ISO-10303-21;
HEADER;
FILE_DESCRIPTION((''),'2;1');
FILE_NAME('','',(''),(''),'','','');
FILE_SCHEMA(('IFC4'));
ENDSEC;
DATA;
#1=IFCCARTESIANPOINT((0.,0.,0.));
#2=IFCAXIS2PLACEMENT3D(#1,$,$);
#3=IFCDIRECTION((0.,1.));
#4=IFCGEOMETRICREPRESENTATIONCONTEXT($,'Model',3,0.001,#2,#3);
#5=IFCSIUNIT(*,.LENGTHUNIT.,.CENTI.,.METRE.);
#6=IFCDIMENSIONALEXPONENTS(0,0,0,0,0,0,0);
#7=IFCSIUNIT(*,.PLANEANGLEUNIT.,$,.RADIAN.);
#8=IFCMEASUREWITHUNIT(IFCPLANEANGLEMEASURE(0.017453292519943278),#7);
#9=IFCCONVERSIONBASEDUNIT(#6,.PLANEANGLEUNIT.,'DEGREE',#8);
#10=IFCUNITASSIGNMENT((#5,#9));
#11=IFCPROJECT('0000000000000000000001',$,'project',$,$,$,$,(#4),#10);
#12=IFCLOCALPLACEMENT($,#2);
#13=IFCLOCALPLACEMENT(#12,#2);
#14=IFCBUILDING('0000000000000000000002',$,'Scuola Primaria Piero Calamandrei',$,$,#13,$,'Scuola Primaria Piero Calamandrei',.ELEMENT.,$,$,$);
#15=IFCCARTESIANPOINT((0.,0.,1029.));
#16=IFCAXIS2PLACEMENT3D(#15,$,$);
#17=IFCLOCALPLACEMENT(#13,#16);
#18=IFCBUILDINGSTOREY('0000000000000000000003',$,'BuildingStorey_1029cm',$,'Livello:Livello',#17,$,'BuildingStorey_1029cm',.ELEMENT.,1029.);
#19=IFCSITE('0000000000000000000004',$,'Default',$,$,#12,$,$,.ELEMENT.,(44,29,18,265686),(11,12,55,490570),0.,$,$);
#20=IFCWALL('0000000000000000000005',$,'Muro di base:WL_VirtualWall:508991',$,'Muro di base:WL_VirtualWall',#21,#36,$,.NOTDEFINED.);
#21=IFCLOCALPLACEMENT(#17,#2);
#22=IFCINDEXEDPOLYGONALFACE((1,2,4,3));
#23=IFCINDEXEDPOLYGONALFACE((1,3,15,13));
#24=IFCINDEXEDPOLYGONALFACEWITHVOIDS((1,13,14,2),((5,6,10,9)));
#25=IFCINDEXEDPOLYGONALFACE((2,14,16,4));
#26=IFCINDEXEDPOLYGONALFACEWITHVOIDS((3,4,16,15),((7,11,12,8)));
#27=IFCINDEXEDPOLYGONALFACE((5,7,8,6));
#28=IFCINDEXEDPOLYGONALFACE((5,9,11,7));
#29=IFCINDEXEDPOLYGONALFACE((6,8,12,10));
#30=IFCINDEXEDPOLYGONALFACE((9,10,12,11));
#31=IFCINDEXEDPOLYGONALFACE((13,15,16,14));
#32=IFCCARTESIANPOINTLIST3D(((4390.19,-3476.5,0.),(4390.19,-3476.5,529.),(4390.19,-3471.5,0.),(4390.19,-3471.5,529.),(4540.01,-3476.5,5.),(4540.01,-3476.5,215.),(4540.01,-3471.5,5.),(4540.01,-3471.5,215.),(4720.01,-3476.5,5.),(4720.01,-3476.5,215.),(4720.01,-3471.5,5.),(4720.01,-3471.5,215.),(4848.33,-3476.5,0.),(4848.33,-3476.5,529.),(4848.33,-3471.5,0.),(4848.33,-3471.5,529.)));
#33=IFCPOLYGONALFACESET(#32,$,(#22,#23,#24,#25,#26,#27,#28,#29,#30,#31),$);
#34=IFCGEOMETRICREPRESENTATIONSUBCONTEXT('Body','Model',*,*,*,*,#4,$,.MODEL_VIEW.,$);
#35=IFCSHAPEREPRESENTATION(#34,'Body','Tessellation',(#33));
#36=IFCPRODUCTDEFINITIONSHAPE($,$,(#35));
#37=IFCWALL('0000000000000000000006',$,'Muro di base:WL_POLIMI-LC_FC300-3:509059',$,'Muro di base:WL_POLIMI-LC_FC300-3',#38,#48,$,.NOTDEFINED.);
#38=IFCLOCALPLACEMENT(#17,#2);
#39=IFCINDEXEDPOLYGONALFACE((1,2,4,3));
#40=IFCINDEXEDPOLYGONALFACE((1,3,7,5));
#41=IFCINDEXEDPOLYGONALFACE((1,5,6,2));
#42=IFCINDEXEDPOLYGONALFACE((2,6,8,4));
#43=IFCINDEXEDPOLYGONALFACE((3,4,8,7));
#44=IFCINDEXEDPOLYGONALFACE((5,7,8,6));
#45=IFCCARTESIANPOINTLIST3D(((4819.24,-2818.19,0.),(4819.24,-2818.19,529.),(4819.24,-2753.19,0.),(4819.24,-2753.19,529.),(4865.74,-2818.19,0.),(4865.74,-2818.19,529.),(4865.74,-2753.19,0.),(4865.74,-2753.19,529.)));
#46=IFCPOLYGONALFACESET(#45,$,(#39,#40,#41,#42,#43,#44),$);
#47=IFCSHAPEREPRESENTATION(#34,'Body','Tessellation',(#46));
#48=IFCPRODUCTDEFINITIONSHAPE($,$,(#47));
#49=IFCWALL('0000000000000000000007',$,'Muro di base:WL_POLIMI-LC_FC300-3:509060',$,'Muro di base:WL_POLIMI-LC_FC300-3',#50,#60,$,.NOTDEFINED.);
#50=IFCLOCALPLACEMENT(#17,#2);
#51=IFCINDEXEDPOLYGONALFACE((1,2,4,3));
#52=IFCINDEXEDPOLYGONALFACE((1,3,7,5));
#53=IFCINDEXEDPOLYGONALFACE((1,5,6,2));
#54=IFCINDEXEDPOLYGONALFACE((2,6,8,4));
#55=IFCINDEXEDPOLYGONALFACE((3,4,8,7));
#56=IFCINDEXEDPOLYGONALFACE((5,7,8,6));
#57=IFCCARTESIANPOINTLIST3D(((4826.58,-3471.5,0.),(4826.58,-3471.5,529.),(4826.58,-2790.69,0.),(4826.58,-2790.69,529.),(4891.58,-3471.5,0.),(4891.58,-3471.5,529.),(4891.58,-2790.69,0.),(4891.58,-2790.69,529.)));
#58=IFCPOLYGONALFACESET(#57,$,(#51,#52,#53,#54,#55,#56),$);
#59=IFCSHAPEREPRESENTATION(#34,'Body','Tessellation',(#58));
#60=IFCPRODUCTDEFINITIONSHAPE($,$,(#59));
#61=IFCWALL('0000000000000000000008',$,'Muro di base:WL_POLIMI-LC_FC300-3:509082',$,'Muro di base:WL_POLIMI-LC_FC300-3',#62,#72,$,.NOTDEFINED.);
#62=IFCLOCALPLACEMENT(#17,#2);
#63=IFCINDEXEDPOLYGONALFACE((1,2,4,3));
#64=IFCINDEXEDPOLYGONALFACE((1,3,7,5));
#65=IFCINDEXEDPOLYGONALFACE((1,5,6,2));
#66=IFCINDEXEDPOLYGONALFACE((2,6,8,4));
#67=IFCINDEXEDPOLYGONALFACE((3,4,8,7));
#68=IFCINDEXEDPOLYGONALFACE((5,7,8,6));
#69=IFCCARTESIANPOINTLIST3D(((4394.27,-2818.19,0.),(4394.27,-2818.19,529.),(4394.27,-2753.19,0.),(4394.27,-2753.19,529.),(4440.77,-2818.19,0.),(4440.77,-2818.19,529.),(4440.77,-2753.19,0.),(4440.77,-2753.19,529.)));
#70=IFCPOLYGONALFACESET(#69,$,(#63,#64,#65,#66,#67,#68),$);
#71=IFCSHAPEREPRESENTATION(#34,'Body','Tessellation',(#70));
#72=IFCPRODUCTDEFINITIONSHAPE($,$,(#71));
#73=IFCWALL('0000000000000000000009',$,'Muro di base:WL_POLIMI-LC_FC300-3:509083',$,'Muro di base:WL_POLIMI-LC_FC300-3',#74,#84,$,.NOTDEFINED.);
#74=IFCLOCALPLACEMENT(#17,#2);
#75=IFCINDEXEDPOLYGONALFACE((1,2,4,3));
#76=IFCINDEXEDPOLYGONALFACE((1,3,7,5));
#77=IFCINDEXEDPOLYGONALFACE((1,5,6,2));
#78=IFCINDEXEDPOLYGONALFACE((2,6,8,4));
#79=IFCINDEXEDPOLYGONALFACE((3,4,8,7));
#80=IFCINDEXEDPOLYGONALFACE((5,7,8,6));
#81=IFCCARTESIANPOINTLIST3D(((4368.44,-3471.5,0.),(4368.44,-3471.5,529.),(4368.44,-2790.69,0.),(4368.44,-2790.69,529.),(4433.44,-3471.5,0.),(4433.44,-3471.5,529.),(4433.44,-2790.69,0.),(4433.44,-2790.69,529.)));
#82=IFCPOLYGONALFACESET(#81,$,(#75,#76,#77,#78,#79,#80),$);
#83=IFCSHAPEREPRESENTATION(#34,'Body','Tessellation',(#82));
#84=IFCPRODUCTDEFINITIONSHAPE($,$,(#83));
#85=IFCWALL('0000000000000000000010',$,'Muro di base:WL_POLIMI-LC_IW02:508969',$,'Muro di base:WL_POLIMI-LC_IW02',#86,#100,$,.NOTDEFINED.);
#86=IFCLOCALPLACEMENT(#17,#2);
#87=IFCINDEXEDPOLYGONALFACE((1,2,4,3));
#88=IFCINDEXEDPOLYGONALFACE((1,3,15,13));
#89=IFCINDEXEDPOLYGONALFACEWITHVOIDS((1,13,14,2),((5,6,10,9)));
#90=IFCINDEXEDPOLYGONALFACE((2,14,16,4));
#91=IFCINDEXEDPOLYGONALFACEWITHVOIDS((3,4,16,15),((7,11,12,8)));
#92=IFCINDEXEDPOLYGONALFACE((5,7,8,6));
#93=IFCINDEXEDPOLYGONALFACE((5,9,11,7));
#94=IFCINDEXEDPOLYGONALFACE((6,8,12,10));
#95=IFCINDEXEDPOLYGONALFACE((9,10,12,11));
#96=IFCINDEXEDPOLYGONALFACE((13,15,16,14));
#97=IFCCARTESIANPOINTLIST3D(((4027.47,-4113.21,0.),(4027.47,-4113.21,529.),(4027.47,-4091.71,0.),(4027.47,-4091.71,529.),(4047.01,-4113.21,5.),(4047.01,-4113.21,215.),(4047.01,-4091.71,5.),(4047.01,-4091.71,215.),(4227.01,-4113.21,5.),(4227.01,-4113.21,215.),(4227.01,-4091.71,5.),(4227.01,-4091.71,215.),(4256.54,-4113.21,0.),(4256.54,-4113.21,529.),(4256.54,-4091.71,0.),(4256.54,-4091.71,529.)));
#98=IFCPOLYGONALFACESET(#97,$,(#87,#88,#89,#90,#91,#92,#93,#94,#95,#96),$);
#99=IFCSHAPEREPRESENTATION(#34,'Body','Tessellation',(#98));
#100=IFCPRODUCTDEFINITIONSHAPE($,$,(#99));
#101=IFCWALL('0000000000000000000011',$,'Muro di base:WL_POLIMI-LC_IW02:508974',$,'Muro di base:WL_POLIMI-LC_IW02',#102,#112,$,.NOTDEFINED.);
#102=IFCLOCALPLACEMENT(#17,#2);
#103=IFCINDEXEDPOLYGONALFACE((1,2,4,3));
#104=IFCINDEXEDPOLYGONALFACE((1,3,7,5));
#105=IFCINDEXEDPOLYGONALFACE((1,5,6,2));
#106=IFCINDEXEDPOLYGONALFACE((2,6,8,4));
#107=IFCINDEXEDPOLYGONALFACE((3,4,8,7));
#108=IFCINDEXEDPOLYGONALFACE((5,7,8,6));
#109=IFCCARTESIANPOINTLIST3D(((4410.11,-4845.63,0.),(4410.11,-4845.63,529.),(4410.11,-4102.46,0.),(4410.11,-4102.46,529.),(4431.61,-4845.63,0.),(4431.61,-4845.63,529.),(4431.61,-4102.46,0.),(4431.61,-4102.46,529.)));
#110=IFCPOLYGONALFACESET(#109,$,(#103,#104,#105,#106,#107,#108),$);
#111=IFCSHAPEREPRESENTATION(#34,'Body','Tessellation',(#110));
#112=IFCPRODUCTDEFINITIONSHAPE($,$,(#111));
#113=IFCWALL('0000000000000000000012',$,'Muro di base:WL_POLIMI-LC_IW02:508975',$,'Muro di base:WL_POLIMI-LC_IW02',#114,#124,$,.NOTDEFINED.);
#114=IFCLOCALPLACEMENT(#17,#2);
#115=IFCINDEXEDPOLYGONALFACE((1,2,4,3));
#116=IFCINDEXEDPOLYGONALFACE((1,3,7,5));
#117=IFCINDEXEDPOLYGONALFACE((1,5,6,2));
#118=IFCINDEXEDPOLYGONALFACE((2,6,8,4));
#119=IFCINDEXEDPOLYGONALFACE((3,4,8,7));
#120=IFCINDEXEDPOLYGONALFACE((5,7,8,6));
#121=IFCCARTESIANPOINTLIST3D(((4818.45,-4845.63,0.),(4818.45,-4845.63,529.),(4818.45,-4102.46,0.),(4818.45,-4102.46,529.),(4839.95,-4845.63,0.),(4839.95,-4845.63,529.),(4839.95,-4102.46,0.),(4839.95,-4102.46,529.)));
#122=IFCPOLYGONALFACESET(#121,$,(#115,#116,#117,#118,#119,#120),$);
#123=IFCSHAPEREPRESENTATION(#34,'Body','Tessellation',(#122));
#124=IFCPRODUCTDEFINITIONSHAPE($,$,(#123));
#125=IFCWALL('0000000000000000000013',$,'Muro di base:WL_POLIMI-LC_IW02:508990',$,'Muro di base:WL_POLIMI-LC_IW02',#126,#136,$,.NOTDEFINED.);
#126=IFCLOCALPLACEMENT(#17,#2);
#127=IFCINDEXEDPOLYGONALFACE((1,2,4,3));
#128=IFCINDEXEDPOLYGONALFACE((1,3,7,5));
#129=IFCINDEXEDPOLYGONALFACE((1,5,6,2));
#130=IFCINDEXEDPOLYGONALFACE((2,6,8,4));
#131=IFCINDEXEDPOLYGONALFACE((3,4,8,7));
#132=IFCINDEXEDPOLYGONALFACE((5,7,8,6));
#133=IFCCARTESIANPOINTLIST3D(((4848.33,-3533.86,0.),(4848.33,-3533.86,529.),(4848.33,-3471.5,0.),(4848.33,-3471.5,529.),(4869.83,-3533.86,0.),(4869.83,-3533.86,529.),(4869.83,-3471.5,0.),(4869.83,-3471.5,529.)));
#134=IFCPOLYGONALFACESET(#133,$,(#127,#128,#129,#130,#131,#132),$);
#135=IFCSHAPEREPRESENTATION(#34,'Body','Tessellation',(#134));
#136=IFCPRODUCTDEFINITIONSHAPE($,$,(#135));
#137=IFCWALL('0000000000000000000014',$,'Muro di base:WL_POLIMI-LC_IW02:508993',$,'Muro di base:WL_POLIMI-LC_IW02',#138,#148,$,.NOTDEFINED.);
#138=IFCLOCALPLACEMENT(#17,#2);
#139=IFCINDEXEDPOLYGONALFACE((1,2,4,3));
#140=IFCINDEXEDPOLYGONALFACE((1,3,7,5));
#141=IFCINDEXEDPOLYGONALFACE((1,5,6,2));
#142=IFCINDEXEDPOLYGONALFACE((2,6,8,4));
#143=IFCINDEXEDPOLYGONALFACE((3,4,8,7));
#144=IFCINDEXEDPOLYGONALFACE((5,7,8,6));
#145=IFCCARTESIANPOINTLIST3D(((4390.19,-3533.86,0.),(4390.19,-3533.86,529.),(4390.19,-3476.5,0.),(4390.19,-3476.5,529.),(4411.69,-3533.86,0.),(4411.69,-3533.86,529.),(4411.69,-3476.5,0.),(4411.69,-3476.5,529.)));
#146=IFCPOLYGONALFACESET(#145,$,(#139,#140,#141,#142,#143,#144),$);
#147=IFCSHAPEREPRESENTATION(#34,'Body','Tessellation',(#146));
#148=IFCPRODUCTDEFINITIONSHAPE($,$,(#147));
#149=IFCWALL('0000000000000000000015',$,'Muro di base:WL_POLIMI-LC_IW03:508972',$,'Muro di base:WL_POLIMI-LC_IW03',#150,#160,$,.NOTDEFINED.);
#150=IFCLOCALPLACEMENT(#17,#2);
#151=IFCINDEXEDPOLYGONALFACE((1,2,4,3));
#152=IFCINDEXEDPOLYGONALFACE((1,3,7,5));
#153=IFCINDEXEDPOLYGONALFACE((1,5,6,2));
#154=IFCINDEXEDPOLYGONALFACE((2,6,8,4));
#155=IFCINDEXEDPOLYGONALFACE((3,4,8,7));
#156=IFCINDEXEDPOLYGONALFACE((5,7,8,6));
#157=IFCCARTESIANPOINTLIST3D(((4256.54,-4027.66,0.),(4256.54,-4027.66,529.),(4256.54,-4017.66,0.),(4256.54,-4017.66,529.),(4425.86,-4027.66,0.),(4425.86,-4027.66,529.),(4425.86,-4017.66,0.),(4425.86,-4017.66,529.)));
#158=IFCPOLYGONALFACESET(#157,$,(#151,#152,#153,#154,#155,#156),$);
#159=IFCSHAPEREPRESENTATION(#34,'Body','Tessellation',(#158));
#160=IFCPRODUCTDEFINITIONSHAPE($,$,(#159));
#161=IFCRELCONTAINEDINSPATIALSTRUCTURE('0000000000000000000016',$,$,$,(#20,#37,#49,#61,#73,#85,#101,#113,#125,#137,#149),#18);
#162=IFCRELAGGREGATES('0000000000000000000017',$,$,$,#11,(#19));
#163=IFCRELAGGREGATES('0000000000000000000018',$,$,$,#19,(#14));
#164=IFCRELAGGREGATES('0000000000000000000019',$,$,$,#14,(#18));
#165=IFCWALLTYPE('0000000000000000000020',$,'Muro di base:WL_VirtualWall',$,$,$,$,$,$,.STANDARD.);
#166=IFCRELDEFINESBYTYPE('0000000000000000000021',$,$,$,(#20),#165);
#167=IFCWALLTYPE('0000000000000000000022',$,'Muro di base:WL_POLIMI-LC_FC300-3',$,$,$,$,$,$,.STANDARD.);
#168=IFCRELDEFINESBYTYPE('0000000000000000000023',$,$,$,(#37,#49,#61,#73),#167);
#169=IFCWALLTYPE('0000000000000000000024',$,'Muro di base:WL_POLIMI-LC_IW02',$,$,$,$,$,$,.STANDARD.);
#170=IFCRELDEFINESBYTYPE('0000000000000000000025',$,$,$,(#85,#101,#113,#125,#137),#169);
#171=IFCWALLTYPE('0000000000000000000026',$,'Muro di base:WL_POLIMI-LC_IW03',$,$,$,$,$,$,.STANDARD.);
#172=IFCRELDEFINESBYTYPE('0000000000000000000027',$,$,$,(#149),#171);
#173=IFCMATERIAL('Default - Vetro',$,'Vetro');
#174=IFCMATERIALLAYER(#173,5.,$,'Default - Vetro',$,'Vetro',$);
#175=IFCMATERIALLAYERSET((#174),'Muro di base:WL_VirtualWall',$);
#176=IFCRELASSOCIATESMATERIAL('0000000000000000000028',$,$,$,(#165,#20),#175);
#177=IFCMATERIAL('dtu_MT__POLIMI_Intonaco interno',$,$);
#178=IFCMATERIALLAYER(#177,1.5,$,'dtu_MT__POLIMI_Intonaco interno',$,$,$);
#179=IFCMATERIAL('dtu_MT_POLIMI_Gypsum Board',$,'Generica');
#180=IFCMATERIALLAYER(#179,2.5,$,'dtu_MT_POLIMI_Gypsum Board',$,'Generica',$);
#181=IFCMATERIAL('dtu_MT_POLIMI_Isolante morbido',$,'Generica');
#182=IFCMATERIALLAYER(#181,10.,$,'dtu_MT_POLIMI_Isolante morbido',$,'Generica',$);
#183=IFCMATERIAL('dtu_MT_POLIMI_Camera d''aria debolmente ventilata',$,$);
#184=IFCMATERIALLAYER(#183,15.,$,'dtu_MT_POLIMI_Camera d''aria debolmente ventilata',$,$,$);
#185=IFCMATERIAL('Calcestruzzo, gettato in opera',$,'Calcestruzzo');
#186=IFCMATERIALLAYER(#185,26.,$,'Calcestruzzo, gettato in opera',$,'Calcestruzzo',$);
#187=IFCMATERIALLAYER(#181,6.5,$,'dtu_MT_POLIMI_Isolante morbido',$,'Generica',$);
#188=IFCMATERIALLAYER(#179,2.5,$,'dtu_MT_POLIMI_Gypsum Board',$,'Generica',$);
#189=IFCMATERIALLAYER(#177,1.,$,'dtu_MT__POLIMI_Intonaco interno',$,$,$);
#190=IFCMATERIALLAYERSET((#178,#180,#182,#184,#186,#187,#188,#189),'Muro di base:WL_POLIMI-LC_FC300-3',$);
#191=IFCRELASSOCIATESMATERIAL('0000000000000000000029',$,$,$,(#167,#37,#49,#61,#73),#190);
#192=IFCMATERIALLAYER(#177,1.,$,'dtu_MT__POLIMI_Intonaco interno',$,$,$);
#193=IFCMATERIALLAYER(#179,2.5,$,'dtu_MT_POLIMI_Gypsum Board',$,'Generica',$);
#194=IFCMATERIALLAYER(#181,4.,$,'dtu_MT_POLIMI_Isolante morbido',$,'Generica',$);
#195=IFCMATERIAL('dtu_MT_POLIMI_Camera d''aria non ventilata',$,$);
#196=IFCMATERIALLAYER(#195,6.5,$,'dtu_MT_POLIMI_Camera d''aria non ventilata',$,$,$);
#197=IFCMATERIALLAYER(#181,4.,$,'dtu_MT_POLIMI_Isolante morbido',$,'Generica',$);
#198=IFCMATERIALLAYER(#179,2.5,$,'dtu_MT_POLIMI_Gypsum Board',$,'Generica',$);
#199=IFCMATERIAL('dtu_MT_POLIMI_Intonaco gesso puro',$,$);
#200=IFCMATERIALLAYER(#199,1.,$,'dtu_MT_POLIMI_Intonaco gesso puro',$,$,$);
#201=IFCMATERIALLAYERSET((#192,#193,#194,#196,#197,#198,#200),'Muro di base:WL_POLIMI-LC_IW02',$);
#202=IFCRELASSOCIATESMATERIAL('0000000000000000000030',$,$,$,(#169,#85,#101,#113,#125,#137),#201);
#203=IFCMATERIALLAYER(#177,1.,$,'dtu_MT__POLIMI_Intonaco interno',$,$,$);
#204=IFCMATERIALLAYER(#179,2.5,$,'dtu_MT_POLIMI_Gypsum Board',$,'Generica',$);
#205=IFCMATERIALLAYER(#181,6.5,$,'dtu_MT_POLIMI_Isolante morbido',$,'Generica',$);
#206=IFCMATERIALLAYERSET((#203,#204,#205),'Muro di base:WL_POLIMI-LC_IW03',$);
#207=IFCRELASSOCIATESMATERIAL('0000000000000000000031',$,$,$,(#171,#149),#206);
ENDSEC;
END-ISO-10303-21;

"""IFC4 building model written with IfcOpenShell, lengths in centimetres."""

from ifc_helpers import new_model, entity, si_unit, converted_unit, direction, frame, frame_2d, origin, place, context, subcontext, project, spatial, rectangle, extrude, material, layer, layer_set, layer_usage, type_object, element, save


model = new_model("IFC4")

# Units and contexts
model_context = context("Model", 3, precision=0.001, world=origin(), true_north=direction((0.0, 1.0)))
body_context = subcontext(model_context, "Body", "Model", "MODEL_VIEW")
ifc_project = project(units=[si_unit("LENGTHUNIT", "METRE", prefix="CENTI"), converted_unit("PLANEANGLEUNIT", "DEGREE", entity("IfcPlaneAngleMeasure", 0.017453292519943278), si_unit("PLANEANGLEUNIT", "RADIAN"), dimensions=[0, 0, 0, 0, 0, 0, 0])], contexts=[model_context])

# Site, building, storey
site_placement = place(None, origin())
site = spatial("IfcSite", under=ifc_project, at=site_placement, Name="Default", CompositionType="ELEMENT", RefLatitude=(44, 29, 18, 265686), RefLongitude=(11, 12, 55, 490570), RefElevation=0.0)
building_placement = place(site_placement, origin())
building = spatial("IfcBuilding", under=site, at=building_placement, Name="Scuola Primaria Piero Calamandrei", LongName="Scuola Primaria Piero Calamandrei", CompositionType="ELEMENT")
storey_placement = place(building_placement, frame((0.0, 0.0, 1029.0)))
storey = spatial("IfcBuildingStorey", under=building, at=storey_placement, Name="BuildingStorey_1029cm", ObjectType="Livello:Livello", LongName="BuildingStorey_1029cm", CompositionType="ELEMENT", Elevation=1029.0)

# Shared definitions
ifc_material_1 = material(Name="Default - Vetro", Category="Vetro")

# Shared definitions
ifc_material_2 = material(Name="dtu_MT_POLIMI_Camera d'aria debolmente ventilata")
ifc_material_3 = material(Name="dtu_MT_POLIMI_Isolante morbido", Category="Generica")
ifc_material_4 = material(Name="dtu_MT_POLIMI_Gypsum Board", Category="Generica")
ifc_material_5 = material(Name="dtu_MT__POLIMI_Intonaco interno")

# Wall, opening
ifc_layer_1 = layer(ifc_material_1, 5.0, Name="Default - Vetro", Category="Vetro")
ifc_layer_set_1 = layer_set([ifc_layer_1], Name="Muro di base:WL_VirtualWall")
ifc_layer_usage_1 = layer_usage(ifc_layer_set_1, "AXIS2", "NEGATIVE", 2.5)
wall_type_1 = type_object("IfcWallType", Name="Muro di base:WL_VirtualWall", PredefinedType="STANDARD", material=ifc_layer_set_1)
wall_1_placement = place(storey_placement, frame((4390.19, -3474.0, 0.0)))
wall_1 = element("IfcWall", 1, at=wall_1_placement, inside=storey, type_object=wall_type_1, material=ifc_layer_usage_1, Name="Muro di base:WL_VirtualWall:508991", ObjectType="Muro di base:WL_VirtualWall", PredefinedType="NOTDEFINED", context=body_context, shape_type="SweptSolid", body=[
    extrude(rectangle(XDim=458.14, YDim=5.0, at=frame_2d((229.07, 0.0), x_axis=(-1.0, 0.0))), origin(), (0.0, 0.0, 1.0), 529.0),
])
opening_1_placement = place(wall_1_placement, frame((149.82, -2.5, 5.0)))
element("IfcOpeningElement", 2, at=opening_1_placement, cuts=wall_1, PredefinedType="OPENING", context=body_context, shape_type="SweptSolid", body=[
    extrude(rectangle(XDim=210.0, YDim=180.0, at=frame_2d((105.0, 90.0), x_axis=(1.0, 0.0))), frame((0.0, 0.0, 0.0), z_axis=(0.0, 1.0, 0.0), x_axis=(0.0, 0.0, 1.0)), (0.0, 0.0, 1.0), 5.0),
])

# Walls
ifc_layer_2 = layer(ifc_material_5, 1.5, Name="dtu_MT__POLIMI_Intonaco interno")
ifc_layer_3 = layer(ifc_material_4, 2.5, Name="dtu_MT_POLIMI_Gypsum Board", Category="Generica")
ifc_layer_4 = layer(ifc_material_3, 10.0, Name="dtu_MT_POLIMI_Isolante morbido", Category="Generica")
ifc_layer_5 = layer(ifc_material_2, 15.0, Name="dtu_MT_POLIMI_Camera d'aria debolmente ventilata")
ifc_material_6 = material(Name="Calcestruzzo, gettato in opera", Category="Calcestruzzo")
ifc_layer_6 = layer(ifc_material_6, 26.0, Name="Calcestruzzo, gettato in opera", Category="Calcestruzzo")
ifc_layer_7 = layer(ifc_material_3, 6.5, Name="dtu_MT_POLIMI_Isolante morbido", Category="Generica")
ifc_layer_8 = layer(ifc_material_4, 2.5, Name="dtu_MT_POLIMI_Gypsum Board", Category="Generica")
ifc_layer_9 = layer(ifc_material_5, 1.0, Name="dtu_MT__POLIMI_Intonaco interno")
ifc_layer_set_2 = layer_set([ifc_layer_2, ifc_layer_3, ifc_layer_4, ifc_layer_5, ifc_layer_6, ifc_layer_7, ifc_layer_8, ifc_layer_9], Name="Muro di base:WL_POLIMI-LC_FC300-3")
ifc_layer_usage_2 = layer_usage(ifc_layer_set_2, "AXIS2", "NEGATIVE", 32.5)
wall_type_2 = type_object("IfcWallType", Name="Muro di base:WL_POLIMI-LC_FC300-3", PredefinedType="STANDARD", material=ifc_layer_set_2)
wall_2_placement = place(storey_placement, frame((4865.74, -2785.69, 0.0), z_axis=(0.0, 0.0, 1.0), x_axis=(-1.0, 0.0, 0.0)))
element("IfcWall", 3, at=wall_2_placement, inside=storey, type_object=wall_type_2, material=ifc_layer_usage_2, Name="Muro di base:WL_POLIMI-LC_FC300-3:509059", ObjectType="Muro di base:WL_POLIMI-LC_FC300-3", PredefinedType="NOTDEFINED", context=body_context, shape_type="SweptSolid", body=[
    extrude(rectangle(XDim=46.5, YDim=65.0, at=frame_2d((23.25, 0.0), x_axis=(-1.0, 0.0))), origin(), (0.0, 0.0, 1.0), 529.0),
])
ifc_layer_usage_3 = layer_usage(ifc_layer_set_2, "AXIS2", "NEGATIVE", 32.5)
wall_3_placement = place(storey_placement, frame((4859.08, -3471.5, 0.0), z_axis=(0.0, 0.0, 1.0), x_axis=(0.0, 1.0, 0.0)))
element("IfcWall", 4, at=wall_3_placement, inside=storey, type_object=wall_type_2, material=ifc_layer_usage_3, Name="Muro di base:WL_POLIMI-LC_FC300-3:509060", ObjectType="Muro di base:WL_POLIMI-LC_FC300-3", PredefinedType="NOTDEFINED", context=body_context, shape_type="SweptSolid", body=[
    extrude(rectangle(XDim=680.81, YDim=65.0, at=frame_2d((340.41, 0.0), x_axis=(-1.0, 0.0))), origin(), (0.0, 0.0, 1.0), 529.0),
])
ifc_layer_usage_4 = layer_usage(ifc_layer_set_2, "AXIS2", "NEGATIVE", 32.5)
wall_4_placement = place(storey_placement, frame((4394.27, -2785.69, 0.0)))
element("IfcWall", 5, at=wall_4_placement, inside=storey, type_object=wall_type_2, material=ifc_layer_usage_4, Name="Muro di base:WL_POLIMI-LC_FC300-3:509082", ObjectType="Muro di base:WL_POLIMI-LC_FC300-3", PredefinedType="NOTDEFINED", context=body_context, shape_type="SweptSolid", body=[
    extrude(rectangle(XDim=46.5, YDim=65.0, at=frame_2d((23.25, 0.0), x_axis=(-1.0, 0.0))), origin(), (0.0, 0.0, 1.0), 529.0),
])
ifc_layer_usage_5 = layer_usage(ifc_layer_set_2, "AXIS2", "NEGATIVE", 32.5)
wall_5_placement = place(storey_placement, frame((4400.94, -3471.5, 0.0), z_axis=(0.0, 0.0, 1.0), x_axis=(0.0, 1.0, 0.0)))
element("IfcWall", 6, at=wall_5_placement, inside=storey, type_object=wall_type_2, material=ifc_layer_usage_5, Name="Muro di base:WL_POLIMI-LC_FC300-3:509083", ObjectType="Muro di base:WL_POLIMI-LC_FC300-3", PredefinedType="NOTDEFINED", context=body_context, shape_type="SweptSolid", body=[
    extrude(rectangle(XDim=680.81, YDim=65.0, at=frame_2d((340.41, 0.0), x_axis=(-1.0, 0.0))), origin(), (0.0, 0.0, 1.0), 529.0),
])

# Wall, opening
ifc_layer_10 = layer(ifc_material_5, 1.0, Name="dtu_MT__POLIMI_Intonaco interno")
ifc_layer_11 = layer(ifc_material_4, 2.5, Name="dtu_MT_POLIMI_Gypsum Board", Category="Generica")
ifc_layer_12 = layer(ifc_material_3, 4.0, Name="dtu_MT_POLIMI_Isolante morbido", Category="Generica")
ifc_material_7 = material(Name="dtu_MT_POLIMI_Camera d'aria non ventilata")
ifc_layer_13 = layer(ifc_material_7, 6.5, Name="dtu_MT_POLIMI_Camera d'aria non ventilata")
ifc_layer_14 = layer(ifc_material_3, 4.0, Name="dtu_MT_POLIMI_Isolante morbido", Category="Generica")
ifc_layer_15 = layer(ifc_material_4, 2.5, Name="dtu_MT_POLIMI_Gypsum Board", Category="Generica")
ifc_material_8 = material(Name="dtu_MT_POLIMI_Intonaco gesso puro")
ifc_layer_16 = layer(ifc_material_8, 1.0, Name="dtu_MT_POLIMI_Intonaco gesso puro")
ifc_layer_set_3 = layer_set([ifc_layer_10, ifc_layer_11, ifc_layer_12, ifc_layer_13, ifc_layer_14, ifc_layer_15, ifc_layer_16], Name="Muro di base:WL_POLIMI-LC_IW02")
ifc_layer_usage_6 = layer_usage(ifc_layer_set_3, "AXIS2", "NEGATIVE", 10.75)
wall_type_3 = type_object("IfcWallType", Name="Muro di base:WL_POLIMI-LC_IW02", PredefinedType="STANDARD", material=ifc_layer_set_3)
wall_6_placement = place(storey_placement, frame((4256.54, -4102.46, 0.0), z_axis=(0.0, 0.0, 1.0), x_axis=(-1.0, 0.0, 0.0)))
wall_6 = element("IfcWall", 7, at=wall_6_placement, inside=storey, type_object=wall_type_3, material=ifc_layer_usage_6, Name="Muro di base:WL_POLIMI-LC_IW02:508969", ObjectType="Muro di base:WL_POLIMI-LC_IW02", PredefinedType="NOTDEFINED", context=body_context, shape_type="SweptSolid", body=[
    extrude(rectangle(XDim=229.07, YDim=21.5, at=frame_2d((114.54, 0.0), x_axis=(-1.0, 0.0))), origin(), (0.0, 0.0, 1.0), 529.0),
])
opening_2_placement = place(wall_6_placement, frame((209.54, 10.75, 5.0)))
element("IfcOpeningElement", 8, at=opening_2_placement, cuts=wall_6, PredefinedType="OPENING", context=body_context, shape_type="SweptSolid", body=[
    extrude(rectangle(XDim=210.0, YDim=180.0, at=frame_2d((105.0, 90.0), x_axis=(-1.0, 0.0))), frame((0.0, 0.0, 0.0), z_axis=(0.0, -1.0, 0.0), x_axis=(0.0, 0.0, 1.0)), (0.0, 0.0, 1.0), 21.5),
])

# Walls
ifc_layer_usage_7 = layer_usage(ifc_layer_set_3, "AXIS2", "NEGATIVE", 10.75)
wall_7_placement = place(storey_placement, frame((4420.86, -4845.63, 0.0), z_axis=(0.0, 0.0, 1.0), x_axis=(0.0, 1.0, 0.0)))
element("IfcWall", 9, at=wall_7_placement, inside=storey, type_object=wall_type_3, material=ifc_layer_usage_7, Name="Muro di base:WL_POLIMI-LC_IW02:508974", ObjectType="Muro di base:WL_POLIMI-LC_IW02", PredefinedType="NOTDEFINED", context=body_context, shape_type="SweptSolid", body=[
    extrude(rectangle(XDim=743.17, YDim=21.5, at=frame_2d((371.58, 0.0), x_axis=(-1.0, 0.0))), origin(), (0.0, 0.0, 1.0), 529.0),
])
ifc_layer_usage_8 = layer_usage(ifc_layer_set_3, "AXIS2", "NEGATIVE", 10.75)
wall_8_placement = place(storey_placement, frame((4829.2, -4102.46, 0.0), z_axis=(0.0, 0.0, 1.0), x_axis=(0.0, -1.0, 0.0)))
element("IfcWall", 10, at=wall_8_placement, inside=storey, type_object=wall_type_3, material=ifc_layer_usage_8, Name="Muro di base:WL_POLIMI-LC_IW02:508975", ObjectType="Muro di base:WL_POLIMI-LC_IW02", PredefinedType="NOTDEFINED", context=body_context, shape_type="SweptSolid", body=[
    extrude(rectangle(XDim=743.17, YDim=21.5, at=frame_2d((371.58, 0.0), x_axis=(-1.0, 0.0))), origin(), (0.0, 0.0, 1.0), 529.0),
])
ifc_layer_usage_9 = layer_usage(ifc_layer_set_3, "AXIS2", "NEGATIVE", 10.75)
wall_9_placement = place(storey_placement, frame((4859.08, -3471.5, 0.0), z_axis=(0.0, 0.0, 1.0), x_axis=(0.0, -1.0, 0.0)))
element("IfcWall", 11, at=wall_9_placement, inside=storey, type_object=wall_type_3, material=ifc_layer_usage_9, Name="Muro di base:WL_POLIMI-LC_IW02:508990", ObjectType="Muro di base:WL_POLIMI-LC_IW02", PredefinedType="NOTDEFINED", context=body_context, shape_type="SweptSolid", body=[
    extrude(rectangle(XDim=62.35, YDim=21.5, at=frame_2d((31.18, 0.0), x_axis=(-1.0, 0.0))), origin(), (0.0, 0.0, 1.0), 529.0),
])
ifc_layer_usage_10 = layer_usage(ifc_layer_set_3, "AXIS2", "NEGATIVE", 10.75)
wall_10_placement = place(storey_placement, frame((4400.94, -3533.86, 0.0), z_axis=(0.0, 0.0, 1.0), x_axis=(0.0, 1.0, 0.0)))
element("IfcWall", 12, at=wall_10_placement, inside=storey, type_object=wall_type_3, material=ifc_layer_usage_10, Name="Muro di base:WL_POLIMI-LC_IW02:508993", ObjectType="Muro di base:WL_POLIMI-LC_IW02", PredefinedType="NOTDEFINED", context=body_context, shape_type="SweptSolid", body=[
    extrude(rectangle(XDim=57.35, YDim=21.5, at=frame_2d((28.68, 0.0), x_axis=(-1.0, 0.0))), origin(), (0.0, 0.0, 1.0), 529.0),
])
ifc_layer_17 = layer(ifc_material_5, 1.0, Name="dtu_MT__POLIMI_Intonaco interno")
ifc_layer_18 = layer(ifc_material_4, 2.5, Name="dtu_MT_POLIMI_Gypsum Board", Category="Generica")
ifc_layer_19 = layer(ifc_material_3, 6.5, Name="dtu_MT_POLIMI_Isolante morbido", Category="Generica")
ifc_layer_set_4 = layer_set([ifc_layer_17, ifc_layer_18, ifc_layer_19], Name="Muro di base:WL_POLIMI-LC_IW03")
ifc_layer_usage_11 = layer_usage(ifc_layer_set_4, "AXIS2", "NEGATIVE", 5.0)
wall_type_4 = type_object("IfcWallType", Name="Muro di base:WL_POLIMI-LC_IW03", PredefinedType="STANDARD", material=ifc_layer_set_4)
wall_11_placement = place(storey_placement, frame((4425.86, -4022.66, 0.0), z_axis=(0.0, 0.0, 1.0), x_axis=(-1.0, 0.0, 0.0)))
element("IfcWall", 13, at=wall_11_placement, inside=storey, type_object=wall_type_4, material=ifc_layer_usage_11, Name="Muro di base:WL_POLIMI-LC_IW03:508972", ObjectType="Muro di base:WL_POLIMI-LC_IW03", PredefinedType="NOTDEFINED", context=body_context, shape_type="SweptSolid", body=[
    extrude(rectangle(XDim=169.31, YDim=10.0, at=frame_2d((84.66, 0.0), x_axis=(-1.0, 0.0))), origin(), (0.0, 0.0, 1.0), 529.0),
])

save(model, "model.ifc")
